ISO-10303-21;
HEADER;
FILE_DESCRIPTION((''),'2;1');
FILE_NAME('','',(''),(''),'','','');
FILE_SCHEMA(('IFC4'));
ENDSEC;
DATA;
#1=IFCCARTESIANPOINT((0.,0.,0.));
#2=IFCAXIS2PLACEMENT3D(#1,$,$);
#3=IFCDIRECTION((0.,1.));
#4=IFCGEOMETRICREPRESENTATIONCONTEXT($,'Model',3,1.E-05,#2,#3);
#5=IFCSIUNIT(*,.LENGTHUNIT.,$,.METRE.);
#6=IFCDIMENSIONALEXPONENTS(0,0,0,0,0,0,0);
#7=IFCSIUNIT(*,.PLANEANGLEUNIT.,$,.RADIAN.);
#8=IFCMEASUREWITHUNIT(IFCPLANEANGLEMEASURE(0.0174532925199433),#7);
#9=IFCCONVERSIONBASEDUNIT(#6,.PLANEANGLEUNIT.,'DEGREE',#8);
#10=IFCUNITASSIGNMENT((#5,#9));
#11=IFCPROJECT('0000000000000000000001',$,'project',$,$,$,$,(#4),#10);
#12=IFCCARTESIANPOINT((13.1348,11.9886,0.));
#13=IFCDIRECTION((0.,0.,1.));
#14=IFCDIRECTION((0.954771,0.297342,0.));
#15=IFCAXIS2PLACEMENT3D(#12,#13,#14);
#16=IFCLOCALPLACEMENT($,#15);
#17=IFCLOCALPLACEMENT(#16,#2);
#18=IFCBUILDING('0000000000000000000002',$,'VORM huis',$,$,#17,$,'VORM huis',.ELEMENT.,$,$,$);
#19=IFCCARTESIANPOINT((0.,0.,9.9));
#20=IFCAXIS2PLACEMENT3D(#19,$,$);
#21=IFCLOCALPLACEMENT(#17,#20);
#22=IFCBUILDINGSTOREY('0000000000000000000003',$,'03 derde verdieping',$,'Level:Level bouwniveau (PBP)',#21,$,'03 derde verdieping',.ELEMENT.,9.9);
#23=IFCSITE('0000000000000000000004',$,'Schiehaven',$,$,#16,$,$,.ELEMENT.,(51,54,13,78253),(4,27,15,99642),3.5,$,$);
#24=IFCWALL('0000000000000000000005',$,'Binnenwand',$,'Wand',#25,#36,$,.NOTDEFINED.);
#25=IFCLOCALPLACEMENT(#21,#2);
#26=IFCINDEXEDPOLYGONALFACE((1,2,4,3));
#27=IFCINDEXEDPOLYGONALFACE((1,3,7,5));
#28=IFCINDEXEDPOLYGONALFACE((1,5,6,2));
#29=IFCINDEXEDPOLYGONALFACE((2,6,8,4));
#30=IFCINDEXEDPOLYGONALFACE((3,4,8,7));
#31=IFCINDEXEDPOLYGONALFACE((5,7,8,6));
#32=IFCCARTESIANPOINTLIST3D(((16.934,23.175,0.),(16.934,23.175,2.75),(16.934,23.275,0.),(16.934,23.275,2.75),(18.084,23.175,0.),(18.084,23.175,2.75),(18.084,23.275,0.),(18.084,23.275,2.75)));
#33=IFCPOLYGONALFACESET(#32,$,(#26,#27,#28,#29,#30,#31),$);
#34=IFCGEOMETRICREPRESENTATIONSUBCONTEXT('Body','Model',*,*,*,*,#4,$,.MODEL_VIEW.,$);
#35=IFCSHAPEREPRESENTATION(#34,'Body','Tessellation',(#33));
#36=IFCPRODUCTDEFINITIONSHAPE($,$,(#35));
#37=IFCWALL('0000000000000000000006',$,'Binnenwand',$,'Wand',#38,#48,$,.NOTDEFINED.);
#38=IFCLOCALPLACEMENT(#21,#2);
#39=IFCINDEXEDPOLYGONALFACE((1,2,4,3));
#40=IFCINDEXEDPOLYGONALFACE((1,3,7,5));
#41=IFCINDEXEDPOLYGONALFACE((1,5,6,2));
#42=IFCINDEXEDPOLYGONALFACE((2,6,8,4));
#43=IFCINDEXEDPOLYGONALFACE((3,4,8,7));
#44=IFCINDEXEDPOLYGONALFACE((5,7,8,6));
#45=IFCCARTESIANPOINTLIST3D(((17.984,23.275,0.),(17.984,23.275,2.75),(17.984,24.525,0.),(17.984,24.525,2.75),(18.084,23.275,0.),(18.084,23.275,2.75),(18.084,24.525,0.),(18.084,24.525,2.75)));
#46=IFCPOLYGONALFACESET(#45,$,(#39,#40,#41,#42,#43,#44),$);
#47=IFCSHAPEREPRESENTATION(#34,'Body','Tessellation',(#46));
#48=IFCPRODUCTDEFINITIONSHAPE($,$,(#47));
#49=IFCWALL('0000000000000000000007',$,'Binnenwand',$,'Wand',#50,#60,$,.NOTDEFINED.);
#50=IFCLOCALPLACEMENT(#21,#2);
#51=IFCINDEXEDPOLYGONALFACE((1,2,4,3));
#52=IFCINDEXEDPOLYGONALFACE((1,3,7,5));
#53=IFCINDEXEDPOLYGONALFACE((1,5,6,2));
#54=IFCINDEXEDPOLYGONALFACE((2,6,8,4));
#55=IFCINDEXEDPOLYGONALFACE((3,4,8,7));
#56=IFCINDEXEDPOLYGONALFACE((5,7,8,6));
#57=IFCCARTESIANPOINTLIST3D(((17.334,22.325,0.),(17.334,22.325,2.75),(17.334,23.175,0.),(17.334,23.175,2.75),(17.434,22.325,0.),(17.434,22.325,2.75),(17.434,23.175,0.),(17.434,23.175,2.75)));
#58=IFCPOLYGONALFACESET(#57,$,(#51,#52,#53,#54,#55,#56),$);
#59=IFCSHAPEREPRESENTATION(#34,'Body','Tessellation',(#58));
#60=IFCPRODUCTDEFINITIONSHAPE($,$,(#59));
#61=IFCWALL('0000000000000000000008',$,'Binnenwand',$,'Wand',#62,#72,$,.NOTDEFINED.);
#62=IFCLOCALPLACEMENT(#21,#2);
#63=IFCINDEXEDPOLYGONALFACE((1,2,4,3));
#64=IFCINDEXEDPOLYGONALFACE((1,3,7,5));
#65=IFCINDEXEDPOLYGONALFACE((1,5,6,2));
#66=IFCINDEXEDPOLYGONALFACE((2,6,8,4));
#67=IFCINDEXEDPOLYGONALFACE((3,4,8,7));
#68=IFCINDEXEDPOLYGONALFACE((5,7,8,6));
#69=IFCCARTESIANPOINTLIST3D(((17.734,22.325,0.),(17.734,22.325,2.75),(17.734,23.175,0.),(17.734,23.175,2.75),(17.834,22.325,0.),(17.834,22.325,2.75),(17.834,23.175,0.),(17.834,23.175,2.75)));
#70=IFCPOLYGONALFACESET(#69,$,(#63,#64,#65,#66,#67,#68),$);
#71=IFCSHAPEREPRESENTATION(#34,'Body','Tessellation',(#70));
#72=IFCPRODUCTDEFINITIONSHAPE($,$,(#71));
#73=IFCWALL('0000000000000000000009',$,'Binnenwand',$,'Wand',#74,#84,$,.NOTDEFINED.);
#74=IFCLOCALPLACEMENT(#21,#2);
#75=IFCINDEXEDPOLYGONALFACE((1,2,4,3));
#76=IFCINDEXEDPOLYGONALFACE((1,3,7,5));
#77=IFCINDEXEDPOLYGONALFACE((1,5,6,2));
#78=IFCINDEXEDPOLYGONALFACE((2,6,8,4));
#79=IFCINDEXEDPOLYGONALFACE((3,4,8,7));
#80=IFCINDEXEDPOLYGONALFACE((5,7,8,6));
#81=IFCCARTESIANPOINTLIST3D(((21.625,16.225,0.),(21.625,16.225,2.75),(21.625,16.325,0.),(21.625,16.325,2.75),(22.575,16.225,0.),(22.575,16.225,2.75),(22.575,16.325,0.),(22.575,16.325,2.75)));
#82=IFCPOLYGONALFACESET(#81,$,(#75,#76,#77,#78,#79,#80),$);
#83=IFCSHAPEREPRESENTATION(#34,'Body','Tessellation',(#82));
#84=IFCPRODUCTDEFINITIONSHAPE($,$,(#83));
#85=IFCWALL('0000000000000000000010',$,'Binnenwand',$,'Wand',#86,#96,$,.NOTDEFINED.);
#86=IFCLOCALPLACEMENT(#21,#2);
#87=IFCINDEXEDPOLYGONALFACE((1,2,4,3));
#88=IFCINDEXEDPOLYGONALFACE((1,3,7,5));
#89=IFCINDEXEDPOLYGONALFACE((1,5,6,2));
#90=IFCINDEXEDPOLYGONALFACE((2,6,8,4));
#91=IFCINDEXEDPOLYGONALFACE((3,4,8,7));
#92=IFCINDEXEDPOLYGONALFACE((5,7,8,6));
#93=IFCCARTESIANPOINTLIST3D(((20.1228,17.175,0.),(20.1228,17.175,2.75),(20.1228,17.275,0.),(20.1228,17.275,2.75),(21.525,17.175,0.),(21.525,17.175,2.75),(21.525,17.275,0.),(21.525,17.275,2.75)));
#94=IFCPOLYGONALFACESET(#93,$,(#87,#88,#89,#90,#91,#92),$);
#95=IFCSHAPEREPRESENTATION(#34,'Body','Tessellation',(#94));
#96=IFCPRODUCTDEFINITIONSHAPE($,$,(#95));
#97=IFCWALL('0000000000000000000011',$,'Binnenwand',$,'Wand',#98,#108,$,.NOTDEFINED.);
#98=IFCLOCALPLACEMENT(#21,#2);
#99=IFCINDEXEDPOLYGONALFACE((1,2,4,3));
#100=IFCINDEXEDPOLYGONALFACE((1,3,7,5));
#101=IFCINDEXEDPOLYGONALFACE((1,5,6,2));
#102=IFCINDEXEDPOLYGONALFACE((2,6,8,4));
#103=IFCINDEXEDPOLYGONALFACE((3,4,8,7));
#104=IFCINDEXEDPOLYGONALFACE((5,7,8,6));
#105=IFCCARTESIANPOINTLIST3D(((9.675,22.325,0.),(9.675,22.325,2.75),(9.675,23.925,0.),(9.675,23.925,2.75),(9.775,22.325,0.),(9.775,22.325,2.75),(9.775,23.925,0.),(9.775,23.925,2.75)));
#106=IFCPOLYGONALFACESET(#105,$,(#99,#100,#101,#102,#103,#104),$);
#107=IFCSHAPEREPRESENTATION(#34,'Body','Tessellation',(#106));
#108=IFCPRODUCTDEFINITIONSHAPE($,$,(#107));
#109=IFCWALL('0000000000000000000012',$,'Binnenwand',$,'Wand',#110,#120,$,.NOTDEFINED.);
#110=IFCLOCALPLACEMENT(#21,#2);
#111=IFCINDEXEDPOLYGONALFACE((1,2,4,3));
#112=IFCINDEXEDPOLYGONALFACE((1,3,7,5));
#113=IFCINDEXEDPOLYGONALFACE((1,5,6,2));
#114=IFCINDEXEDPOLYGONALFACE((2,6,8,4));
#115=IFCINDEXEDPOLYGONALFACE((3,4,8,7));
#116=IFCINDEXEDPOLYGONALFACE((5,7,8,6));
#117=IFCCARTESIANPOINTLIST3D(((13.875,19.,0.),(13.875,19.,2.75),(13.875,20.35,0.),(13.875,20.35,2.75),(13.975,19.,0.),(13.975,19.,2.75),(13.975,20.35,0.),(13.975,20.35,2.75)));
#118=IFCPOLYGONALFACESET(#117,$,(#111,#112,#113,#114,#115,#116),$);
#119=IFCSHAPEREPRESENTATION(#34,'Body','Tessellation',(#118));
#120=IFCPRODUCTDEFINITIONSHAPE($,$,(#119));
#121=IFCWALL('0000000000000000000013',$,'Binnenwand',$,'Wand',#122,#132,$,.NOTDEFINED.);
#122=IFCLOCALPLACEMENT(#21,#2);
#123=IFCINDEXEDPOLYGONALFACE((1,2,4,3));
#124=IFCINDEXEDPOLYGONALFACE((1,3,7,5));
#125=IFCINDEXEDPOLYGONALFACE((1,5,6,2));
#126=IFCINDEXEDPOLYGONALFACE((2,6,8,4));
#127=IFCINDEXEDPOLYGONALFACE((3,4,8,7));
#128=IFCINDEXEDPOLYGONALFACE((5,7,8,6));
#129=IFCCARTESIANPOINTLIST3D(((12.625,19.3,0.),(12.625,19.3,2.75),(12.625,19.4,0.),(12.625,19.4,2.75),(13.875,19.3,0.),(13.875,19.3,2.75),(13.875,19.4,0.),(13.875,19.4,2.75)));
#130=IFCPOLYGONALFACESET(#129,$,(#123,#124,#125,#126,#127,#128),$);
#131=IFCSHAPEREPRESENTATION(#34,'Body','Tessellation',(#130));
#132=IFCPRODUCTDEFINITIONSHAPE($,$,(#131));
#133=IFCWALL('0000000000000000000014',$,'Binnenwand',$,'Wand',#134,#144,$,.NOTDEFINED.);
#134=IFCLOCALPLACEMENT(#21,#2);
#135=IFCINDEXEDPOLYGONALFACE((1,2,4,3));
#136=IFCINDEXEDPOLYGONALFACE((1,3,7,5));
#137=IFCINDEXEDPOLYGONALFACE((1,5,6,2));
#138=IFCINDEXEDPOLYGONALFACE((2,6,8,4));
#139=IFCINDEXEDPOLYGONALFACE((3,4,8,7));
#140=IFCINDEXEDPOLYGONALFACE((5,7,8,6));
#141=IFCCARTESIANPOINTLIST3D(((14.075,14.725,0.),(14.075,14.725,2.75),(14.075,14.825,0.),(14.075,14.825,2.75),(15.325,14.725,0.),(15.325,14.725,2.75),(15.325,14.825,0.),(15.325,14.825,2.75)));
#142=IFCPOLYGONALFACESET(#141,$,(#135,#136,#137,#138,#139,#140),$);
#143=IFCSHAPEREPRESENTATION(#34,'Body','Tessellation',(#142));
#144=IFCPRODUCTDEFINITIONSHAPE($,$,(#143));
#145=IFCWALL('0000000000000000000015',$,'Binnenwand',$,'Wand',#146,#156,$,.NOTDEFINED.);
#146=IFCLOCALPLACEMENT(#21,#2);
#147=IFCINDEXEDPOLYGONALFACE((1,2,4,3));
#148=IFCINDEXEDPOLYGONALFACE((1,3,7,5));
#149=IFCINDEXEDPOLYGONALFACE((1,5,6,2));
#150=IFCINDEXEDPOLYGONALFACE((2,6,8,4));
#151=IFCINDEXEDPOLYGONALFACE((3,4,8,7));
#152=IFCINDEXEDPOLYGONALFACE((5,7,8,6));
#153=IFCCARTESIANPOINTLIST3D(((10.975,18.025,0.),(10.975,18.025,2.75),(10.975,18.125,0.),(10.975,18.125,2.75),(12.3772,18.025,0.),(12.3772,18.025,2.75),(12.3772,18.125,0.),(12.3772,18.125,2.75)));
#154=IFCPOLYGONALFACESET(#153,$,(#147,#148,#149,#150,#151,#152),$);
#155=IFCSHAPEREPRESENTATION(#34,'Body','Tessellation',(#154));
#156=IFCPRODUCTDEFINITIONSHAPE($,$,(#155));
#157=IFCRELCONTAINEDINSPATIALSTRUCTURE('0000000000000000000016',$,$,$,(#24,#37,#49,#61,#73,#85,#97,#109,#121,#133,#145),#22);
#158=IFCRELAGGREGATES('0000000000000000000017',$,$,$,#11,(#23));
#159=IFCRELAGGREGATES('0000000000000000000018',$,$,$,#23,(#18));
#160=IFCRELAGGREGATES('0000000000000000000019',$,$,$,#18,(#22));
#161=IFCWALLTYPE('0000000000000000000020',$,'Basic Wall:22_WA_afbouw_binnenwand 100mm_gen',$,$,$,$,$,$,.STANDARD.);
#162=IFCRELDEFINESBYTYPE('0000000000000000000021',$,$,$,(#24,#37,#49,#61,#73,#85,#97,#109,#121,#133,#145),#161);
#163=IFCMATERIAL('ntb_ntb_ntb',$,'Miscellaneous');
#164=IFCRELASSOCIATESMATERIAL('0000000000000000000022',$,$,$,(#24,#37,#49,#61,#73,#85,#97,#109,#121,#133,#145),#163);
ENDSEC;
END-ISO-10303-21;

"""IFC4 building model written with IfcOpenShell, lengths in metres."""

from ifc_helpers import new_model, entity, si_unit, converted_unit, direction, frame, origin, place, context, subcontext, project, spatial, indexed_curve, outline, extrude, material, type_object, element, save


model = new_model("IFC4")

# Units and contexts
model_context = context("Model", 3, precision=1e-05, world=origin(), true_north=direction((0.0, 1.0)))
body_context = subcontext(model_context, "Body", "Model", "MODEL_VIEW")
ifc_project = project(units=[si_unit("LENGTHUNIT", "METRE"), converted_unit("PLANEANGLEUNIT", "DEGREE", entity("IfcPlaneAngleMeasure", 0.0174532925199433), si_unit("PLANEANGLEUNIT", "RADIAN"), dimensions=[0, 0, 0, 0, 0, 0, 0])], contexts=[model_context])

# Site, building, storey
site_placement = place(None, frame((13.1348, 11.9886, 0.0), z_axis=(0.0, 0.0, 1.0), x_axis=(0.954771, 0.297342, 0.0)))
site = spatial("IfcSite", under=ifc_project, at=site_placement, Name="Schiehaven", CompositionType="ELEMENT", RefLatitude=(51, 54, 13, 78253), RefLongitude=(4, 27, 15, 99642), RefElevation=3.5)
building_placement = place(site_placement, origin())
building = spatial("IfcBuilding", under=site, at=building_placement, Name="VORM huis", LongName="VORM huis", CompositionType="ELEMENT")
storey_placement = place(building_placement, frame((0.0, 0.0, 9.9)))
storey = spatial("IfcBuildingStorey", under=building, at=storey_placement, Name="03 derde verdieping", ObjectType="Level:Level bouwniveau (PBP)", LongName="03 derde verdieping", CompositionType="ELEMENT", Elevation=9.9)

# Walls
ifc_material_1 = material(Name="ntb_ntb_ntb", Category="Miscellaneous")
wall_type_1 = type_object("IfcWallType", Name="Basic Wall:22_WA_afbouw_binnenwand 100mm_gen", PredefinedType="STANDARD")
wall_1_placement = place(storey_placement, frame((18.084, 23.225, 0.0), z_axis=(0.0, 0.0, 1.0), x_axis=(-1.0, 0.0, 0.0)))
element("IfcWall", 1, at=wall_1_placement, inside=storey, type_object=wall_type_1, material=ifc_material_1, Name="Binnenwand", ObjectType="Wand", PredefinedType="NOTDEFINED", context=body_context, shape_type="SweptSolid", body=[
    extrude(outline(indexed_curve([(1.15, 0.05), (0.0, 0.05), (0.0, -0.05), (1.15, -0.05), (1.15, 0.05)], self_intersect=False)), origin(), (0.0, 0.0, 1.0), 2.75),
])
wall_2_placement = place(storey_placement, frame((18.034, 23.275, 0.0), z_axis=(0.0, 0.0, 1.0), x_axis=(0.0, 1.0, 0.0)))
element("IfcWall", 2, at=wall_2_placement, inside=storey, type_object=wall_type_1, material=ifc_material_1, Name="Binnenwand", ObjectType="Wand", PredefinedType="NOTDEFINED", context=body_context, shape_type="SweptSolid", body=[
    extrude(outline(indexed_curve([(1.25, 0.05), (0.0, 0.05), (0.0, -0.05), (1.25, -0.05), (1.25, 0.05)], self_intersect=False)), origin(), (0.0, 0.0, 1.0), 2.75),
])
wall_3_placement = place(storey_placement, frame((17.384, 22.325, 0.0), z_axis=(0.0, 0.0, 1.0), x_axis=(0.0, 1.0, 0.0)))
element("IfcWall", 3, at=wall_3_placement, inside=storey, type_object=wall_type_1, material=ifc_material_1, Name="Binnenwand", ObjectType="Wand", PredefinedType="NOTDEFINED", context=body_context, shape_type="SweptSolid", body=[
    extrude(outline(indexed_curve([(0.85, 0.05), (0.0, 0.05), (0.0, -0.05), (0.85, -0.05), (0.85, 0.05)], self_intersect=False)), origin(), (0.0, 0.0, 1.0), 2.75),
])
wall_4_placement = place(storey_placement, frame((17.784, 22.325, 0.0), z_axis=(0.0, 0.0, 1.0), x_axis=(0.0, 1.0, 0.0)))
element("IfcWall", 4, at=wall_4_placement, inside=storey, type_object=wall_type_1, material=ifc_material_1, Name="Binnenwand", ObjectType="Wand", PredefinedType="NOTDEFINED", context=body_context, shape_type="SweptSolid", body=[
    extrude(outline(indexed_curve([(0.85, 0.05), (0.0, 0.05), (0.0, -0.05), (0.85, -0.05), (0.85, 0.05)], self_intersect=False)), origin(), (0.0, 0.0, 1.0), 2.75),
])
wall_5_placement = place(storey_placement, frame((21.625, 16.275, 0.0)))
element("IfcWall", 5, at=wall_5_placement, inside=storey, type_object=wall_type_1, material=ifc_material_1, Name="Binnenwand", ObjectType="Wand", PredefinedType="NOTDEFINED", context=body_context, shape_type="SweptSolid", body=[
    extrude(outline(indexed_curve([(0.95, 0.05), (0.0, 0.05), (0.0, -0.05), (0.95, -0.05), (0.95, 0.05)], self_intersect=False)), origin(), (0.0, 0.0, 1.0), 2.75),
])
wall_6_placement = place(storey_placement, frame((20.1228, 17.225, 0.0)))
element("IfcWall", 6, at=wall_6_placement, inside=storey, type_object=wall_type_1, material=ifc_material_1, Name="Binnenwand", ObjectType="Wand", PredefinedType="NOTDEFINED", context=body_context, shape_type="SweptSolid", body=[
    extrude(outline(indexed_curve([(1.4022, 0.05), (0.0, 0.05), (0.0, -0.05), (1.4022, -0.05), (1.4022, 0.05)], self_intersect=False)), origin(), (0.0, 0.0, 1.0), 2.75),
])
wall_7_placement = place(storey_placement, frame((9.725, 23.925, 0.0), z_axis=(0.0, 0.0, 1.0), x_axis=(0.0, -1.0, 0.0)))
element("IfcWall", 7, at=wall_7_placement, inside=storey, type_object=wall_type_1, material=ifc_material_1, Name="Binnenwand", ObjectType="Wand", PredefinedType="NOTDEFINED", context=body_context, shape_type="SweptSolid", body=[
    extrude(outline(indexed_curve([(1.6, 0.05), (0.0, 0.05), (0.0, -0.05), (1.6, -0.05), (1.6, 0.05)], self_intersect=False)), origin(), (0.0, 0.0, 1.0), 2.75),
])
wall_8_placement = place(storey_placement, frame((13.925, 19.0, 0.0), z_axis=(0.0, 0.0, 1.0), x_axis=(0.0, 1.0, 0.0)))
element("IfcWall", 8, at=wall_8_placement, inside=storey, type_object=wall_type_1, material=ifc_material_1, Name="Binnenwand", ObjectType="Wand", PredefinedType="NOTDEFINED", context=body_context, shape_type="SweptSolid", body=[
    extrude(outline(indexed_curve([(1.35, 0.05), (0.0, 0.05), (0.0, -0.05), (1.35, -0.05), (1.35, 0.05)], self_intersect=False)), origin(), (0.0, 0.0, 1.0), 2.75),
])
wall_9_placement = place(storey_placement, frame((12.625, 19.35, 0.0)))
element("IfcWall", 9, at=wall_9_placement, inside=storey, type_object=wall_type_1, material=ifc_material_1, Name="Binnenwand", ObjectType="Wand", PredefinedType="NOTDEFINED", context=body_context, shape_type="SweptSolid", body=[
    extrude(outline(indexed_curve([(1.25, 0.05), (0.0, 0.05), (0.0, -0.05), (1.25, -0.05), (1.25, 0.05)], self_intersect=False)), origin(), (0.0, 0.0, 1.0), 2.75),
])
wall_10_placement = place(storey_placement, frame((15.325, 14.775, 0.0), z_axis=(0.0, 0.0, 1.0), x_axis=(-1.0, 0.0, 0.0)))
element("IfcWall", 10, at=wall_10_placement, inside=storey, type_object=wall_type_1, material=ifc_material_1, Name="Binnenwand", ObjectType="Wand", PredefinedType="NOTDEFINED", context=body_context, shape_type="SweptSolid", body=[
    extrude(outline(indexed_curve([(1.25, 0.05), (0.0, 0.05), (0.0, -0.05), (1.25, -0.05), (1.25, 0.05)], self_intersect=False)), origin(), (0.0, 0.0, 1.0), 2.75),
])
wall_11_placement = place(storey_placement, frame((12.3772, 18.075, 0.0), z_axis=(0.0, 0.0, 1.0), x_axis=(-1.0, 0.0, 0.0)))
element("IfcWall", 11, at=wall_11_placement, inside=storey, type_object=wall_type_1, material=ifc_material_1, Name="Binnenwand", ObjectType="Wand", PredefinedType="NOTDEFINED", context=body_context, shape_type="SweptSolid", body=[
    extrude(outline(indexed_curve([(1.4022, 0.05), (0.0, 0.05), (0.0, -0.05), (1.4022, -0.05), (1.4022, 0.05)], self_intersect=False)), origin(), (0.0, 0.0, 1.0), 2.75),
])

save(model, "model.ifc")
